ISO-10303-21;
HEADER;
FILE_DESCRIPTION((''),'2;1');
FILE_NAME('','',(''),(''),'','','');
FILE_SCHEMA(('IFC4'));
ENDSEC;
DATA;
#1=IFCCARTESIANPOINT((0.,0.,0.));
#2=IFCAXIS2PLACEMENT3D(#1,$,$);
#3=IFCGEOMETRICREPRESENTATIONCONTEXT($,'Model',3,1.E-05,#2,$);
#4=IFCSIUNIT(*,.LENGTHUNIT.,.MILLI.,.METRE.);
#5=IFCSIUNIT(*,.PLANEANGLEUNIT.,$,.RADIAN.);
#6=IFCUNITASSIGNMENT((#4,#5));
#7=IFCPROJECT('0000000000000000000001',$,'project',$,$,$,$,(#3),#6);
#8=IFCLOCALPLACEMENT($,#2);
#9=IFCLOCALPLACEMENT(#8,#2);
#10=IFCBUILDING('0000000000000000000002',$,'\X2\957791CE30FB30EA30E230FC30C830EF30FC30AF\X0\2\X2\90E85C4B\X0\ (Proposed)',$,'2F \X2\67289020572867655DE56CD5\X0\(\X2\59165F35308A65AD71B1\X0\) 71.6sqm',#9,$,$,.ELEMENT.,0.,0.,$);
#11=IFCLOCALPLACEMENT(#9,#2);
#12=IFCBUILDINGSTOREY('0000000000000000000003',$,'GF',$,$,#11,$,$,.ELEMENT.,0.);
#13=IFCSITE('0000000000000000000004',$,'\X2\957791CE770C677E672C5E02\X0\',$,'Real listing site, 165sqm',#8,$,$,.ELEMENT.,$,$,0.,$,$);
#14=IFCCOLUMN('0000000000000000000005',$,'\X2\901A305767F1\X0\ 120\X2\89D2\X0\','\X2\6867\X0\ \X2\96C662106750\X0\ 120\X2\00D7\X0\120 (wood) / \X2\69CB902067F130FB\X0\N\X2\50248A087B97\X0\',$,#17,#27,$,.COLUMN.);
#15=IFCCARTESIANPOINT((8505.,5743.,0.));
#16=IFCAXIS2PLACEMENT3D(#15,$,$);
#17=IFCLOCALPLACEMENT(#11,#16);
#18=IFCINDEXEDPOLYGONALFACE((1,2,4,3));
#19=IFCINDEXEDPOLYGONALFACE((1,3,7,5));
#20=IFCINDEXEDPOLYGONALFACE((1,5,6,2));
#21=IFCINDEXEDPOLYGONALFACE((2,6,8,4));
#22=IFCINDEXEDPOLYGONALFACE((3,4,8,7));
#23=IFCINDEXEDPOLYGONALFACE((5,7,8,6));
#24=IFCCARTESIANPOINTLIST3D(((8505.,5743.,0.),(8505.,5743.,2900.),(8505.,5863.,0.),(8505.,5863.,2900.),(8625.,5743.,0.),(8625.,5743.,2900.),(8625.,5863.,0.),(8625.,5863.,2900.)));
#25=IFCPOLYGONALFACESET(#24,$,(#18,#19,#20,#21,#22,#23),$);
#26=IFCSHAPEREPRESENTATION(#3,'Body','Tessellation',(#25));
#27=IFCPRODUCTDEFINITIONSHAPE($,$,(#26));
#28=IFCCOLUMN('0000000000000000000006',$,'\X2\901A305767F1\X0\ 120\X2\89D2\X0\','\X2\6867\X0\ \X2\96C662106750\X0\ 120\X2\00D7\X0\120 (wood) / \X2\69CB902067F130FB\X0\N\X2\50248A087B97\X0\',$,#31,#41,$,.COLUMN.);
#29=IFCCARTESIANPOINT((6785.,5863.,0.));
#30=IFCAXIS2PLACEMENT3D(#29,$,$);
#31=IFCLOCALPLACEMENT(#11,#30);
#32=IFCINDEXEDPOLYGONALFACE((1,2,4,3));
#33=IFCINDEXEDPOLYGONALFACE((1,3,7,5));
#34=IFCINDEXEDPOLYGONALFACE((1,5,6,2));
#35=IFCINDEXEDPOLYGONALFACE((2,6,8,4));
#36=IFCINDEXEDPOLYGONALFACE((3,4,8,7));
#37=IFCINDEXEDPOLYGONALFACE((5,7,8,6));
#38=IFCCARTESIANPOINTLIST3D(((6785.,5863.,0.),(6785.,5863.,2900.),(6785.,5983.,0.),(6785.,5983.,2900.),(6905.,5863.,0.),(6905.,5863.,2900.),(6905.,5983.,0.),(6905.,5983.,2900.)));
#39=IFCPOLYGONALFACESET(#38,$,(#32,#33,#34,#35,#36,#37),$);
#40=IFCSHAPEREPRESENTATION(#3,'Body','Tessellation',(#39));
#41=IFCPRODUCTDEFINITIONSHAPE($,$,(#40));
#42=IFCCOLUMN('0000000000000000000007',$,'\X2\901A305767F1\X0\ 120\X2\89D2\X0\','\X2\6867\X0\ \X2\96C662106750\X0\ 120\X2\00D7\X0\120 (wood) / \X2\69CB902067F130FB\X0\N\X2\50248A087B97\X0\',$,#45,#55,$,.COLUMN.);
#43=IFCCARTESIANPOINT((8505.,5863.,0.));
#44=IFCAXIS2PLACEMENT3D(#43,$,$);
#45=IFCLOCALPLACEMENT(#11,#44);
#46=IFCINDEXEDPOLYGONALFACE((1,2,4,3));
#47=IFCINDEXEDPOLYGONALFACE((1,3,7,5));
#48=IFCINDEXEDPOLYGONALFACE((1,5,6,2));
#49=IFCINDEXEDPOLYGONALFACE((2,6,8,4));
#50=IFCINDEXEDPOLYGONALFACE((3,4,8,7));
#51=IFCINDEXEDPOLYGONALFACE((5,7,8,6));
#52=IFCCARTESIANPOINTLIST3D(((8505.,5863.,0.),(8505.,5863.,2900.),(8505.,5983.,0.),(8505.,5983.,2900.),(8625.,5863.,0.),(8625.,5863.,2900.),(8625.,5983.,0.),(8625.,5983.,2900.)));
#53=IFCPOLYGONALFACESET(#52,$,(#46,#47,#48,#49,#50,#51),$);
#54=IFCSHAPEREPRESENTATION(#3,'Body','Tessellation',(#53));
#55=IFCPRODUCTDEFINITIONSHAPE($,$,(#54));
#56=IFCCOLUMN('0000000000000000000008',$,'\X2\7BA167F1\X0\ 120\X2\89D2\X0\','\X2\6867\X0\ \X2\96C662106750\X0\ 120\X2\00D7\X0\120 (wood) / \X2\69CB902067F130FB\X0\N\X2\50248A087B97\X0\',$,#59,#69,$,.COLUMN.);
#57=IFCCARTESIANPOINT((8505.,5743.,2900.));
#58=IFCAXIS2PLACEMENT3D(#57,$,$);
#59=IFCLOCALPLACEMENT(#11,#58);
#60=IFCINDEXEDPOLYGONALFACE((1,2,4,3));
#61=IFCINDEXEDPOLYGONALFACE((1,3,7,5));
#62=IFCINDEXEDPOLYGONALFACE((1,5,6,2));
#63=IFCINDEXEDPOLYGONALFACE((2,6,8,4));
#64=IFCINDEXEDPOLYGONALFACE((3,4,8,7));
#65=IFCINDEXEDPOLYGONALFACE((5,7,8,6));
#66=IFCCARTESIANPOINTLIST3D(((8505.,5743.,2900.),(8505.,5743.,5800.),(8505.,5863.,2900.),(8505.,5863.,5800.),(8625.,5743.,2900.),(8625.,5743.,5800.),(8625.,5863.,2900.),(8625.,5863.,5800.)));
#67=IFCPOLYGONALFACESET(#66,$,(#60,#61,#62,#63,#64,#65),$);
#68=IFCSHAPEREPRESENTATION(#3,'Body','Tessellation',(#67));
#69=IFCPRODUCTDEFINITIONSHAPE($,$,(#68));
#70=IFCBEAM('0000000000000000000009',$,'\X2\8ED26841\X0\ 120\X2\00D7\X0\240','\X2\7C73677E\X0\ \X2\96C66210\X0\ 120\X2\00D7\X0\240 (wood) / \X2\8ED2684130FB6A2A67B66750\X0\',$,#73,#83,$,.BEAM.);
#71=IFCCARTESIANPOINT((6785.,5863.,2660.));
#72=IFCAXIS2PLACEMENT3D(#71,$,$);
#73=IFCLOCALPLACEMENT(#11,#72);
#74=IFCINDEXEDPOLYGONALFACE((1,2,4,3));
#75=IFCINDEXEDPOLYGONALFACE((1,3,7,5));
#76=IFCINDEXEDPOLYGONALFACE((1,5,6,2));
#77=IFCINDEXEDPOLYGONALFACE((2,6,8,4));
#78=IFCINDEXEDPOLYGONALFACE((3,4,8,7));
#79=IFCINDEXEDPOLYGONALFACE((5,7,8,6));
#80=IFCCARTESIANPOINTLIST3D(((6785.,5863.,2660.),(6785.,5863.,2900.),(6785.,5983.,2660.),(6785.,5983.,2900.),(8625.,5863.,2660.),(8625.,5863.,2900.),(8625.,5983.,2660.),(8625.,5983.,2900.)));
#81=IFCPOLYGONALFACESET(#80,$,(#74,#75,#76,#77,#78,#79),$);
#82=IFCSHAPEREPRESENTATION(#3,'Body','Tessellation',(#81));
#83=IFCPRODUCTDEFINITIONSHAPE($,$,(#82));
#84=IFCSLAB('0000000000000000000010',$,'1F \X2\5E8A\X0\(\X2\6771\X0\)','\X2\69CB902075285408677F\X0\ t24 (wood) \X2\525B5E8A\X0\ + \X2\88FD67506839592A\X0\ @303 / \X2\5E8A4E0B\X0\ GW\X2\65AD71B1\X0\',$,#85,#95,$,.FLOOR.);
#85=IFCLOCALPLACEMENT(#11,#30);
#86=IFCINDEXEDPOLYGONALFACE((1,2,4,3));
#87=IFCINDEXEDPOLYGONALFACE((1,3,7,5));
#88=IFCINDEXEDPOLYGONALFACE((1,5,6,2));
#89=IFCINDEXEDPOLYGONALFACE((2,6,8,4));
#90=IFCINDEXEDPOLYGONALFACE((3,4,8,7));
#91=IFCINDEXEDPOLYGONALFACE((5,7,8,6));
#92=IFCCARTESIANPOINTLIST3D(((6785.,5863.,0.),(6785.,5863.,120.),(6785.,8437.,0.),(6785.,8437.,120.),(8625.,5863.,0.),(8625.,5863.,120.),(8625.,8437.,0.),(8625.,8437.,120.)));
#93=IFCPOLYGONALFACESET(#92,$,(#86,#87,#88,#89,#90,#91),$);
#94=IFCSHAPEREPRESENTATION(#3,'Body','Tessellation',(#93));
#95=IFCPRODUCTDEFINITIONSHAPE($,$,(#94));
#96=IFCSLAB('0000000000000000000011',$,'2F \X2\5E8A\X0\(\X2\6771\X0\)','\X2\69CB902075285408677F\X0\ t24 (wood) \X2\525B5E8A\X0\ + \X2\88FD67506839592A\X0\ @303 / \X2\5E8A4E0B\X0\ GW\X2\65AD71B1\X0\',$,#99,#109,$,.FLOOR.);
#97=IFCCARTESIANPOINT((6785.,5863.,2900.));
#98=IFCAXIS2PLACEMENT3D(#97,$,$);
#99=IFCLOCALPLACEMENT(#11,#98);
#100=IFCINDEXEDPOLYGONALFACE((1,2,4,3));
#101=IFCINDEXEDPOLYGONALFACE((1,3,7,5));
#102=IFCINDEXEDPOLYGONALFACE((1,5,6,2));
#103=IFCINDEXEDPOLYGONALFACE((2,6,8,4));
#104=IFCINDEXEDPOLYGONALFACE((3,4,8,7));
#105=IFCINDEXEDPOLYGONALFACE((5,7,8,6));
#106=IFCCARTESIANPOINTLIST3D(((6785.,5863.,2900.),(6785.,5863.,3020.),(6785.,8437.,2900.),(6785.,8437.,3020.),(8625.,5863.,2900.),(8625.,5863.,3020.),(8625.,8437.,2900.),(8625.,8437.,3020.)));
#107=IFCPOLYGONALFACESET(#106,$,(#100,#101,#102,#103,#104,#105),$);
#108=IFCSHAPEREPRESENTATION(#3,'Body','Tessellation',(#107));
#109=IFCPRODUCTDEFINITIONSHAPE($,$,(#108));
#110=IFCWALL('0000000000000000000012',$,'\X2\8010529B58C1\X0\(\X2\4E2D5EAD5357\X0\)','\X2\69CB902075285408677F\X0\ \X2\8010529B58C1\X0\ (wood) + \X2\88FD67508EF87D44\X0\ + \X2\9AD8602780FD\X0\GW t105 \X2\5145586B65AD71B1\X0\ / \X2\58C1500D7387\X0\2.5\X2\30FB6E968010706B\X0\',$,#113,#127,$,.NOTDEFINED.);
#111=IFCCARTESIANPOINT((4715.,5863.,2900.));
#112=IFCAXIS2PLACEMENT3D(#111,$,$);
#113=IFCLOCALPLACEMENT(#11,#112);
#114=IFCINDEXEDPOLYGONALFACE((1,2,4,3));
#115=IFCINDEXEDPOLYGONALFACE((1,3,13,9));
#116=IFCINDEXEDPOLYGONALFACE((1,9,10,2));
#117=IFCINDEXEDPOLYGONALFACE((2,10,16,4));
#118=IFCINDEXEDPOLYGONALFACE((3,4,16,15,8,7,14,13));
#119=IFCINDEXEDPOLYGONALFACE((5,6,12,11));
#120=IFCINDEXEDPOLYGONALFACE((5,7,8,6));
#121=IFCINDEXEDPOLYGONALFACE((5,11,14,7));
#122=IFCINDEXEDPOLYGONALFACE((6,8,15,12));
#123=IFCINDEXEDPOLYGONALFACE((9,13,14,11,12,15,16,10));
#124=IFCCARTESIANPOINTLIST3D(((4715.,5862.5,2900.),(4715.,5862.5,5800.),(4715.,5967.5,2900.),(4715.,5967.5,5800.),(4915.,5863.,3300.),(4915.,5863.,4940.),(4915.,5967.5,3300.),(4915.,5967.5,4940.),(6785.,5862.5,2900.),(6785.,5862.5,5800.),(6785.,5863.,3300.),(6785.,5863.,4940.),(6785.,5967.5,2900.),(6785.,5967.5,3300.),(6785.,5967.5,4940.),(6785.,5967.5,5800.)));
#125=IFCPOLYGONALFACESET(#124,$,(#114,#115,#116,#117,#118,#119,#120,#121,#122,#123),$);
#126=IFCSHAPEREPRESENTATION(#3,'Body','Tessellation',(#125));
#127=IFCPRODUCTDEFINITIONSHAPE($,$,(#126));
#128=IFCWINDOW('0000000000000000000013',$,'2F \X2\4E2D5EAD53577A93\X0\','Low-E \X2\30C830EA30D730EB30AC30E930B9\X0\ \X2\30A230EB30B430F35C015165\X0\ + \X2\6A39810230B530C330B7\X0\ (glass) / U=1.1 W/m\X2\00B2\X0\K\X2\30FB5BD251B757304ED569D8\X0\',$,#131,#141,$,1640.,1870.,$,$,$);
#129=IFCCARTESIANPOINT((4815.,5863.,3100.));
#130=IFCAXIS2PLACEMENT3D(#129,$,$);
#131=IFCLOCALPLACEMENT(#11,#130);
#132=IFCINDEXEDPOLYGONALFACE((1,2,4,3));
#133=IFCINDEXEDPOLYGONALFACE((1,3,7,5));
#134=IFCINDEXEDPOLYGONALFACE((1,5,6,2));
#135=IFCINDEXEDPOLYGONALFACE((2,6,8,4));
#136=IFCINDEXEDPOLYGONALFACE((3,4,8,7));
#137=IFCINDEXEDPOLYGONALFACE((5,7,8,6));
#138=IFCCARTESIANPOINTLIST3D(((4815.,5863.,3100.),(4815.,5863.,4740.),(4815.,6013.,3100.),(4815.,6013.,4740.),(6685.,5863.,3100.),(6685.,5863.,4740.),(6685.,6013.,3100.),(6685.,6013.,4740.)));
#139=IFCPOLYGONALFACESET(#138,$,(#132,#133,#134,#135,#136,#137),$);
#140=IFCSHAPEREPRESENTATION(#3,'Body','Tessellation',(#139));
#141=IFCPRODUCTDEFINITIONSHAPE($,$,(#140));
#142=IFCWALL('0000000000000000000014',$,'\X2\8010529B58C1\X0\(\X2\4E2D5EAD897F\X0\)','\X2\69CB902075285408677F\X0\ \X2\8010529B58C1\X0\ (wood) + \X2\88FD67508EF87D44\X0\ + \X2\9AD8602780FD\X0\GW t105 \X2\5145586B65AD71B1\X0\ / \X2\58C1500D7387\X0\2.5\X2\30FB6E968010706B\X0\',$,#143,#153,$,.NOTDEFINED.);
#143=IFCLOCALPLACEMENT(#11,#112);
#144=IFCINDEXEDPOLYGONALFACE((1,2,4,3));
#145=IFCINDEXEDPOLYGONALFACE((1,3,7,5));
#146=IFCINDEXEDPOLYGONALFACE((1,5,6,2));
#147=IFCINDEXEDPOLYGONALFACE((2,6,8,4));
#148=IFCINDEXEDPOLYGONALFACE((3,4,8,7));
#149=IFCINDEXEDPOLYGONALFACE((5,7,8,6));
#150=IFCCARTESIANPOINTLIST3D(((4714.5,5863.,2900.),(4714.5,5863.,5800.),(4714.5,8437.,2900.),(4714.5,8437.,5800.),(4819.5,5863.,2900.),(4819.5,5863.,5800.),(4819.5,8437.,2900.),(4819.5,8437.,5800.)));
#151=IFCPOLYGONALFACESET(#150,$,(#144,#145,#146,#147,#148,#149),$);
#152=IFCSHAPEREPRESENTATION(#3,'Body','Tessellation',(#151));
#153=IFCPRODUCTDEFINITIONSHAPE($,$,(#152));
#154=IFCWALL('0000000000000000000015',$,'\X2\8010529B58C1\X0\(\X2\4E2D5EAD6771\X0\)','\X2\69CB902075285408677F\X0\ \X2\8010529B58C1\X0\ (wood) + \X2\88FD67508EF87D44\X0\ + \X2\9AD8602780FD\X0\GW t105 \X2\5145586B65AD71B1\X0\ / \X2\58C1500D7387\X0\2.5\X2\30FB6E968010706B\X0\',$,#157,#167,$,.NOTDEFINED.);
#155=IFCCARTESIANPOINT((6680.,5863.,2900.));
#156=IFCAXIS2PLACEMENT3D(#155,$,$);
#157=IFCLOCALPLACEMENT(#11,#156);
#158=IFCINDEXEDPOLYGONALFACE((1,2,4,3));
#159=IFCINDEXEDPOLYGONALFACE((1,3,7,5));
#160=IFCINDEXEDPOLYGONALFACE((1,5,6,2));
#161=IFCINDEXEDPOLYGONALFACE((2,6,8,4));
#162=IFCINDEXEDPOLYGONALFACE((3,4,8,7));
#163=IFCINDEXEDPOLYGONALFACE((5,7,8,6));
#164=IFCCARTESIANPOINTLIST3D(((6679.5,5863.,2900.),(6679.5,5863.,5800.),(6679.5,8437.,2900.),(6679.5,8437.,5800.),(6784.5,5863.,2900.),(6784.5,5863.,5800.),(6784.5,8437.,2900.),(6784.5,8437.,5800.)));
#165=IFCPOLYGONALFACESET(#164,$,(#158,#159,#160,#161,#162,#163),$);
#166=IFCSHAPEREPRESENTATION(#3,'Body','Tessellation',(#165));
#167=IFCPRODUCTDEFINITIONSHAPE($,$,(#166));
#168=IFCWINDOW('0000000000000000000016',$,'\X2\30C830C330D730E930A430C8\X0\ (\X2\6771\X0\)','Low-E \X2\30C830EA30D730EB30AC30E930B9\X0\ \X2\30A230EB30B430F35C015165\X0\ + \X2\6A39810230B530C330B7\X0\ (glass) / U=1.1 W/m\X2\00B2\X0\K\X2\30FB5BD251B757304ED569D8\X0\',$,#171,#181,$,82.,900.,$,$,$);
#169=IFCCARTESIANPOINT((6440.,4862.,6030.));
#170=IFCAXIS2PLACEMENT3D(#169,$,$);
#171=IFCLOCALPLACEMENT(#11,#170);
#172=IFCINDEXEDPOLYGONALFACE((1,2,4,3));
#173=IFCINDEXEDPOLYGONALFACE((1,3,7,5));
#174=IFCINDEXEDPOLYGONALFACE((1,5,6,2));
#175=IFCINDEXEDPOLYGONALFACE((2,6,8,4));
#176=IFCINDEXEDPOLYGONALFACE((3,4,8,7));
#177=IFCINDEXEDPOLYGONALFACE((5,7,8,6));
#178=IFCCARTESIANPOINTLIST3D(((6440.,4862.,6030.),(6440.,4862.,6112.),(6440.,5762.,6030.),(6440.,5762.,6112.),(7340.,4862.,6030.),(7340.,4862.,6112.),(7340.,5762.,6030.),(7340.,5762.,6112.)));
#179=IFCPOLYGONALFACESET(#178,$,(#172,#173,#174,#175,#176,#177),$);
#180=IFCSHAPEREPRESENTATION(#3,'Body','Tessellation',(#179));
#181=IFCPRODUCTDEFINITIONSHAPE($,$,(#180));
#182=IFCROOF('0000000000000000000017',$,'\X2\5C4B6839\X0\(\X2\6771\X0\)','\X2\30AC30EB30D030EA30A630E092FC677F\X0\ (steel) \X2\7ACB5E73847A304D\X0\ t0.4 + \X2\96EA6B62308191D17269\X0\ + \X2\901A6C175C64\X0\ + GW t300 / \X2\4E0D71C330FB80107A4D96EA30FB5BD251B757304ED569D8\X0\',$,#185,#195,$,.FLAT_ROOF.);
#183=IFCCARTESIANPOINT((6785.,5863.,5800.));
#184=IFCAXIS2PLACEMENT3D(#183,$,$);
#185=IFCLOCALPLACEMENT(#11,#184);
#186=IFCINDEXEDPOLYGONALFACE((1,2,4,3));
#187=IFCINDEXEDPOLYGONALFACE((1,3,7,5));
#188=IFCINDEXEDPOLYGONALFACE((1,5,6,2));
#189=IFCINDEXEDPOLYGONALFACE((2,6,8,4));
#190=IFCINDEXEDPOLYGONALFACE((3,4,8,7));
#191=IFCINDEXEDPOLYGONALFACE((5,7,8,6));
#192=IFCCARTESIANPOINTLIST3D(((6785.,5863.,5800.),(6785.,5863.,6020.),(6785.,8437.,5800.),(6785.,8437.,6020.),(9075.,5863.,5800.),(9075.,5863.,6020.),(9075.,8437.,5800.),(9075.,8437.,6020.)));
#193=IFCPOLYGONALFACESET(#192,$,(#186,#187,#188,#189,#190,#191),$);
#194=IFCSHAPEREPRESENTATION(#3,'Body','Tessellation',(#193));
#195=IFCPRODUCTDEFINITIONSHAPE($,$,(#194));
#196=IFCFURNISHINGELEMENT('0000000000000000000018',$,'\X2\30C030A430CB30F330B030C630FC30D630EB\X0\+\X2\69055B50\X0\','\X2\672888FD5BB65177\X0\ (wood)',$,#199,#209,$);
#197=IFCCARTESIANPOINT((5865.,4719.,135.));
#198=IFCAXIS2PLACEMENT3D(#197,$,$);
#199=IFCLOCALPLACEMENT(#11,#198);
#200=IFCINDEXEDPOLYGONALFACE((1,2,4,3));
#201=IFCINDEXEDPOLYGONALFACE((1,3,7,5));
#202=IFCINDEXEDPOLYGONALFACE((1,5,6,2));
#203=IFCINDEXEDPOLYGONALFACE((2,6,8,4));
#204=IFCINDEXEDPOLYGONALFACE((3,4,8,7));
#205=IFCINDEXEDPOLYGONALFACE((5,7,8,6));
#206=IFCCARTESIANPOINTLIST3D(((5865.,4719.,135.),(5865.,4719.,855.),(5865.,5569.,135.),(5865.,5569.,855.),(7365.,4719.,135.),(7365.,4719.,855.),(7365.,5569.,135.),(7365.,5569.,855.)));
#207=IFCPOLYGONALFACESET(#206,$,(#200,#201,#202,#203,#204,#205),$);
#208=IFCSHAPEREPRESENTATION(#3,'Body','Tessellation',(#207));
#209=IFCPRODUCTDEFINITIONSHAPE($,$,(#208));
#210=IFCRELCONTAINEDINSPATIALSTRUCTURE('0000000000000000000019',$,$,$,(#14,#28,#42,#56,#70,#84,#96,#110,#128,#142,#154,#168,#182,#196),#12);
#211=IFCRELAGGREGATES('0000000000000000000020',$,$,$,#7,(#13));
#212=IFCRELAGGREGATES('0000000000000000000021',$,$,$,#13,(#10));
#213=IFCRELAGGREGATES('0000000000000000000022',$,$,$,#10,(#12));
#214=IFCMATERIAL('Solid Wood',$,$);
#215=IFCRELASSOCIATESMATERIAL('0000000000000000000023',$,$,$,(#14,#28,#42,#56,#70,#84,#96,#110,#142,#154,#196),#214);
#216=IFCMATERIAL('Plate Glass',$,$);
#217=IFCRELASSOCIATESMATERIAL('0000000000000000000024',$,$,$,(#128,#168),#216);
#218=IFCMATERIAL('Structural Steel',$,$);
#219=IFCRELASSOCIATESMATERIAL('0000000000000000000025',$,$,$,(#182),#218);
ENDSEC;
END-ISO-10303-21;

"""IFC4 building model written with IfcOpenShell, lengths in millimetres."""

from ifc_helpers import new_model, si_unit, frame, frame_2d, origin, place, context, project, spatial, rectangle, extrude, material, element, fill, save


model = new_model("IFC4")

# Units and contexts
model_context = context("Model", 3, precision=1e-05, world=origin())
ifc_project = project(units=[si_unit("LENGTHUNIT", "METRE", prefix="MILLI"), si_unit("PLANEANGLEUNIT", "RADIAN")], contexts=[model_context])

# Site, building, storey
site_placement = place(None, origin())
site = spatial("IfcSite", under=ifc_project, at=site_placement, Name="長野県松本市", ObjectType="Real listing site, 165sqm", CompositionType="ELEMENT", RefElevation=0.0)
building_placement = place(site_placement, origin())
building = spatial("IfcBuilding", under=site, at=building_placement, Name="長野・リモートワーク2部屋 (Proposed)", ObjectType="2F 木造在来工法(外張り断熱) 71.6sqm", CompositionType="ELEMENT", ElevationOfRefHeight=0.0, ElevationOfTerrain=0.0)
storey_placement = place(building_placement, origin())
storey = spatial("IfcBuildingStorey", under=building, at=storey_placement, Name="GF", CompositionType="ELEMENT", Elevation=0.0)

# Columns
ifc_material_1 = material(Name="Solid Wood")
column_1_placement = place(storey_placement, frame((8505.0, 5743.0, 0.0)))
element("IfcColumn", 1, at=column_1_placement, inside=storey, material=ifc_material_1, Name="通し柱 120角", Description="桧 集成材 120×120 (wood) / 構造柱・N値計算", PredefinedType="COLUMN", context=model_context, shape_type="SweptSolid", body=[
    extrude(rectangle(XDim=120.0, YDim=120.0, at=frame_2d((60.0, 60.0))), frame((8505.0, 5743.0, 0.0)), (0.0, 0.0, 1.0), 2900.0),
])
column_2_placement = place(storey_placement, frame((6785.0, 5863.0, 0.0)))
element("IfcColumn", 2, at=column_2_placement, inside=storey, material=ifc_material_1, Name="通し柱 120角", Description="桧 集成材 120×120 (wood) / 構造柱・N値計算", PredefinedType="COLUMN", context=model_context, shape_type="SweptSolid", body=[
    extrude(rectangle(XDim=120.0, YDim=120.0, at=frame_2d((60.0, 60.0))), frame((6785.0, 5863.0, 0.0)), (0.0, 0.0, 1.0), 2900.0),
])
column_3_placement = place(storey_placement, frame((8505.0, 5863.0, 0.0)))
element("IfcColumn", 3, at=column_3_placement, inside=storey, material=ifc_material_1, Name="通し柱 120角", Description="桧 集成材 120×120 (wood) / 構造柱・N値計算", PredefinedType="COLUMN", context=model_context, shape_type="SweptSolid", body=[
    extrude(rectangle(XDim=120.0, YDim=120.0, at=frame_2d((60.0, 60.0))), frame((8505.0, 5863.0, 0.0)), (0.0, 0.0, 1.0), 2900.0),
])
column_4_placement = place(storey_placement, frame((8505.0, 5743.0, 2900.0)))
element("IfcColumn", 4, at=column_4_placement, inside=storey, material=ifc_material_1, Name="管柱 120角", Description="桧 集成材 120×120 (wood) / 構造柱・N値計算", PredefinedType="COLUMN", context=model_context, shape_type="SweptSolid", body=[
    extrude(rectangle(XDim=120.0, YDim=120.0, at=frame_2d((60.0, 60.0))), frame((8505.0, 5743.0, 2900.0)), (0.0, 0.0, 1.0), 2900.0),
])

# Beam
beam_1_placement = place(storey_placement, frame((6785.0, 5863.0, 2660.0)))
element("IfcBeam", 5, at=beam_1_placement, inside=storey, material=ifc_material_1, Name="軒桁 120×240", Description="米松 集成 120×240 (wood) / 軒桁・横架材", PredefinedType="BEAM", context=model_context, shape_type="SweptSolid", body=[
    extrude(rectangle(XDim=1840.0, YDim=120.0, at=frame_2d((920.0, 60.0))), frame((6785.0, 5863.0, 2660.0)), (0.0, 0.0, 1.0), 240.0),
])

# Slabs
slab_1_placement = place(storey_placement, frame((6785.0, 5863.0, 0.0)))
element("IfcSlab", 6, at=slab_1_placement, inside=storey, material=ifc_material_1, Name="1F 床(東)", Description="構造用合板 t24 (wood) 剛床 + 製材根太 @303 / 床下 GW断熱", PredefinedType="FLOOR", context=model_context, shape_type="SweptSolid", body=[
    extrude(rectangle(XDim=1840.0, YDim=2574.0, at=frame_2d((920.0, 1287.0))), frame((6785.0, 5863.0, 0.0)), (0.0, 0.0, 1.0), 120.0),
])
slab_2_placement = place(storey_placement, frame((6785.0, 5863.0, 2900.0)))
element("IfcSlab", 7, at=slab_2_placement, inside=storey, material=ifc_material_1, Name="2F 床(東)", Description="構造用合板 t24 (wood) 剛床 + 製材根太 @303 / 床下 GW断熱", PredefinedType="FLOOR", context=model_context, shape_type="SweptSolid", body=[
    extrude(rectangle(XDim=1840.0, YDim=2574.0, at=frame_2d((920.0, 1287.0))), frame((6785.0, 5863.0, 2900.0)), (0.0, 0.0, 1.0), 120.0),
])

# Wall, opening, window
wall_1_placement = place(storey_placement, frame((4715.0, 5863.0, 2900.0)))
wall_1 = element("IfcWall", 8, at=wall_1_placement, inside=storey, material=ifc_material_1, Name="耐力壁(中庭南)", Description="構造用合板 耐力壁 (wood) + 製材軸組 + 高性能GW t105 充填断熱 / 壁倍率2.5・準耐火", PredefinedType="NOTDEFINED", context=model_context, shape_type="SweptSolid", body=[
    extrude(rectangle(XDim=2070.0, YDim=105.0, at=frame_2d((1035.0, 52.0))), frame((4715.0, 5863.0, 2900.0)), (0.0, 0.0, 1.0), 2900.0),
])
opening_placement = place(storey_placement, frame((4815.0, 5863.0, 3100.0)))
opening = element("IfcOpeningElement", 9, at=opening_placement, cuts=wall_1, PredefinedType="NOTDEFINED", context=model_context, shape_type="SweptSolid", body=[
    extrude(rectangle(XDim=1870.0, YDim=150.0, at=frame_2d((935.0, 75.0))), frame((4815.0, 5863.0, 3100.0)), (0.0, 0.0, 1.0), 1640.0),
])
ifc_material_2 = material(Name="Plate Glass")
window_1_placement = place(storey_placement, frame((4815.0, 5863.0, 3100.0)))
window_1 = element("IfcWindow", 10, at=window_1_placement, inside=storey, material=ifc_material_2, Name="2F 中庭南窓", Description="Low-E トリプルガラス アルゴン封入 + 樹脂サッシ (glass) / U=1.1 W/m²K・寒冷地仕様", OverallHeight=1640.0, OverallWidth=1870.0, context=model_context, shape_type="SweptSolid", body=[
    extrude(rectangle(XDim=1870.0, YDim=150.0, at=frame_2d((935.0, 75.0))), frame((4815.0, 5863.0, 3100.0)), (0.0, 0.0, 1.0), 1640.0),
])
fill(opening, window_1)

# Walls
wall_2_placement = place(storey_placement, frame((4715.0, 5863.0, 2900.0)))
element("IfcWall", 11, at=wall_2_placement, inside=storey, material=ifc_material_1, Name="耐力壁(中庭西)", Description="構造用合板 耐力壁 (wood) + 製材軸組 + 高性能GW t105 充填断熱 / 壁倍率2.5・準耐火", PredefinedType="NOTDEFINED", context=model_context, shape_type="SweptSolid", body=[
    extrude(rectangle(XDim=105.0, YDim=2574.0, at=frame_2d((52.0, 1287.0))), frame((4715.0, 5863.0, 2900.0)), (0.0, 0.0, 1.0), 2900.0),
])
wall_3_placement = place(storey_placement, frame((6680.0, 5863.0, 2900.0)))
element("IfcWall", 12, at=wall_3_placement, inside=storey, material=ifc_material_1, Name="耐力壁(中庭東)", Description="構造用合板 耐力壁 (wood) + 製材軸組 + 高性能GW t105 充填断熱 / 壁倍率2.5・準耐火", PredefinedType="NOTDEFINED", context=model_context, shape_type="SweptSolid", body=[
    extrude(rectangle(XDim=105.0, YDim=2574.0, at=frame_2d((52.0, 1287.0))), frame((6680.0, 5863.0, 2900.0)), (0.0, 0.0, 1.0), 2900.0),
])

# Window
window_2_placement = place(storey_placement, frame((6440.0, 4862.0, 6030.0)))
element("IfcWindow", 13, at=window_2_placement, inside=storey, material=ifc_material_2, Name="トップライト (東)", Description="Low-E トリプルガラス アルゴン封入 + 樹脂サッシ (glass) / U=1.1 W/m²K・寒冷地仕様", OverallHeight=82.0, OverallWidth=900.0, context=model_context, shape_type="SweptSolid", body=[
    extrude(rectangle(XDim=900.0, YDim=900.0, at=frame_2d((450.0, 450.0))), frame((6440.0, 4862.0, 6030.0)), (0.0, 0.0, 1.0), 82.0),
])

# Roof
ifc_material_3 = material(Name="Structural Steel")
for number, where, name in (
    (14, (6785.0, 5863.0, 5800.0), "屋根(東)"),
):
    element("IfcRoof", number, at=place(storey_placement, frame(where)), inside=storey, material=ifc_material_3, Name=name, Description="ガルバリウム鋼板 (steel) 立平葺き t0.4 + 雪止め金物 + 通気層 + GW t300 / 不燃・耐積雪・寒冷地仕様", PredefinedType="FLAT_ROOF", context=model_context, shape_type="SweptSolid", body=[
        extrude(rectangle(XDim=2290.0, YDim=2574.0, at=frame_2d((1145.0, 1287.0))), frame((6785.0, 5863.0, 5800.0)), (0.0, 0.0, 1.0), 220.0),
    ])

# Furnishing element
furnishing_1_placement = place(storey_placement, frame((5865.0, 4719.0, 135.0)))
element("IfcFurnishingElement", 15, at=furnishing_1_placement, inside=storey, material=ifc_material_1, Name="ダイニングテーブル+椅子", Description="木製家具 (wood)", context=model_context, shape_type="SweptSolid", body=[
    extrude(rectangle(XDim=1500.0, YDim=850.0, at=frame_2d((750.0, 425.0))), frame((5865.0, 4719.0, 135.0)), (0.0, 0.0, 1.0), 720.0),
])

save(model, "model.ifc")
